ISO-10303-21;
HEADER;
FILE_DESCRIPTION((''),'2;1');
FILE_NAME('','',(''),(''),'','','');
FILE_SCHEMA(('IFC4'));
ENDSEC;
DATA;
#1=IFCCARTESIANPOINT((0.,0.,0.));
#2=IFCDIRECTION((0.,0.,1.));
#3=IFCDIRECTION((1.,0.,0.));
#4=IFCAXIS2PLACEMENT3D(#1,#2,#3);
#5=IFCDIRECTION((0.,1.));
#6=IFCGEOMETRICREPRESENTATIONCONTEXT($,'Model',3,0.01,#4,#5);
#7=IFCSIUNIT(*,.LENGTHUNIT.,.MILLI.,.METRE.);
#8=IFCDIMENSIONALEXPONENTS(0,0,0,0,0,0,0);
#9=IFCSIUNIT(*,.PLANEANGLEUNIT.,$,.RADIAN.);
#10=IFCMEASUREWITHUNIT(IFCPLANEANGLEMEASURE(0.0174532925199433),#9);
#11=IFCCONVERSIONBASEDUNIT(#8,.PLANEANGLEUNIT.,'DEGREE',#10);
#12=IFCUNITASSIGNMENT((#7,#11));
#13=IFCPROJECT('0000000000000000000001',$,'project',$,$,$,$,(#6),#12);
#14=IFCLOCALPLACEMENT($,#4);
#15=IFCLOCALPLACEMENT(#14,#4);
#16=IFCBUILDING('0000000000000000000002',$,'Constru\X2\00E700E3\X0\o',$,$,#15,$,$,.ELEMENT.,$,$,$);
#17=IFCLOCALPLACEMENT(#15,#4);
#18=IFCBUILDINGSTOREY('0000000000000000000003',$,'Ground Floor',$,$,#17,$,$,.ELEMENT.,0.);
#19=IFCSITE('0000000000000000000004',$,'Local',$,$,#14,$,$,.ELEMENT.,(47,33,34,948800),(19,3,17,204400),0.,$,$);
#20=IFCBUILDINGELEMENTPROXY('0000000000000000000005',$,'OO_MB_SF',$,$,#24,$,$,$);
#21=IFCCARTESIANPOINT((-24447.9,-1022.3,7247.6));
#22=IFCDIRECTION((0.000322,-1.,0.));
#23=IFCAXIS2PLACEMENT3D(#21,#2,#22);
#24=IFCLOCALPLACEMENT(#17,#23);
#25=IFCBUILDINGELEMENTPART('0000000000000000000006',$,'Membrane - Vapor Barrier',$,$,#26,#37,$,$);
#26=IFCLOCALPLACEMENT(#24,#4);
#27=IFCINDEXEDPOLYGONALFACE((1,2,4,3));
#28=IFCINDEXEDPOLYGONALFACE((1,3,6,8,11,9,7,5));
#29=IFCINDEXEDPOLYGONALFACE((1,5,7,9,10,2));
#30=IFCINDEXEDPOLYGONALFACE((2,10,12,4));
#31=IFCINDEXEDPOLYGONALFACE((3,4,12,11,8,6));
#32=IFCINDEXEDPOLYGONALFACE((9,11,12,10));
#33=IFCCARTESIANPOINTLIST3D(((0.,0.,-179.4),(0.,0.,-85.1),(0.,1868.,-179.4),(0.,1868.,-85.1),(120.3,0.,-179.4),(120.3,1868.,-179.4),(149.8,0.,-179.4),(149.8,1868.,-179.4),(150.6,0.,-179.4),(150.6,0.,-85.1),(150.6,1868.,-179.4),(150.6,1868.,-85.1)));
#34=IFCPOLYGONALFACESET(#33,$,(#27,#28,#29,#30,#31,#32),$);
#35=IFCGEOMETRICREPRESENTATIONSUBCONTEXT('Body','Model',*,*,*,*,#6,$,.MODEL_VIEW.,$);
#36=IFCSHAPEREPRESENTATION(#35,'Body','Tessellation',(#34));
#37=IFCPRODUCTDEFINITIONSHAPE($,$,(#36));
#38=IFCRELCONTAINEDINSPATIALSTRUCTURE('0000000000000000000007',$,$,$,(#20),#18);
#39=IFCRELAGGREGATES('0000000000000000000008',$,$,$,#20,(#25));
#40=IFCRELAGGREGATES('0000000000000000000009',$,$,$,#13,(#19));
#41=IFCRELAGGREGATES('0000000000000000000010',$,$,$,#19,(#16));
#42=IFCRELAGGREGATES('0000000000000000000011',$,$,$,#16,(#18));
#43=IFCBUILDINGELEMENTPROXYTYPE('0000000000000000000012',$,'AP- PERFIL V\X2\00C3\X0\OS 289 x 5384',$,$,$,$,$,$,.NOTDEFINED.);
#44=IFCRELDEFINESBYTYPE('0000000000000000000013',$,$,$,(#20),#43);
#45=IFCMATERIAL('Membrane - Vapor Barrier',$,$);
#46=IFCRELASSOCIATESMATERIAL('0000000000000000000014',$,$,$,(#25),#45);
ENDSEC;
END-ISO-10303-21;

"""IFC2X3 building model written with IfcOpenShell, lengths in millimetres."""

from ifc_helpers import new_model, entity, si_unit, converted_unit, direction, frame, origin_with_axes, place, context, subcontext, project, spatial, polyline, outline, extrude, material, type_object, element, aggregate, save


model = new_model("IFC2X3")

# Units and contexts
model_context = context("Model", 3, precision=0.01, world=origin_with_axes(), true_north=direction((0.0, 1.0)))
body_context = subcontext(model_context, "Body", "Model", "MODEL_VIEW")
ifc_project = project(units=[si_unit("LENGTHUNIT", "METRE", prefix="MILLI"), converted_unit("PLANEANGLEUNIT", "DEGREE", entity("IfcPlaneAngleMeasure", 0.0174532925199433), si_unit("PLANEANGLEUNIT", "RADIAN"), dimensions=[0, 0, 0, 0, 0, 0, 0])], contexts=[model_context])

# Site, building, storey
site_placement = place(None, origin_with_axes())
site = spatial("IfcSite", under=ifc_project, at=site_placement, Name="Local", CompositionType="ELEMENT", RefLatitude=(47, 33, 34, 948800), RefLongitude=(19, 3, 17, 204400), RefElevation=0.0)
building_placement = place(site_placement, origin_with_axes())
building = spatial("IfcBuilding", under=site, at=building_placement, Name="Construção", CompositionType="ELEMENT")
storey_placement = place(building_placement, origin_with_axes())
storey = spatial("IfcBuildingStorey", under=building, at=storey_placement, Name="Ground Floor", CompositionType="ELEMENT", Elevation=0.0)

# Building element proxy, building element part
building_element_proxy_type = type_object("IfcBuildingElementProxyType", Name="AP- PERFIL VÃOS 289 x 5384", PredefinedType="NOTDEFINED")
ifc_material = material(Name="Membrane - Vapor Barrier")
proxy_1_placement = place(storey_placement, frame((-24447.9, -1022.3, 7247.6), z_axis=(0.0, 0.0, 1.0), x_axis=(0.000322, -1.0, 0.0)))
proxy_1 = element("IfcBuildingElementProxy", 1, at=proxy_1_placement, inside=storey, type_object=building_element_proxy_type, Name="OO_MB_SF")
building_element_part_1_placement = place(proxy_1_placement, origin_with_axes())
building_element_part_1 = element("IfcBuildingElementPart", 2, at=building_element_part_1_placement, material=ifc_material, Name="Membrane - Vapor Barrier", context=body_context, shape_type="SweptSolid", body=[
    extrude(outline(polyline([(0.0, -85.1), (0.0, -179.4), (120.3, -179.4), (149.8, -179.4), (150.6, -179.4), (150.6, -85.1), (0.0, -85.1)])), frame((0.0, 1868.0, 0.0), z_axis=(0.0, -1.0, 0.0), x_axis=(1.0, 0.0, 0.0)), (0.0, 0.0, 1.0), 1868.0),
])
aggregate(proxy_1, [building_element_part_1])

save(model, "model.ifc")
